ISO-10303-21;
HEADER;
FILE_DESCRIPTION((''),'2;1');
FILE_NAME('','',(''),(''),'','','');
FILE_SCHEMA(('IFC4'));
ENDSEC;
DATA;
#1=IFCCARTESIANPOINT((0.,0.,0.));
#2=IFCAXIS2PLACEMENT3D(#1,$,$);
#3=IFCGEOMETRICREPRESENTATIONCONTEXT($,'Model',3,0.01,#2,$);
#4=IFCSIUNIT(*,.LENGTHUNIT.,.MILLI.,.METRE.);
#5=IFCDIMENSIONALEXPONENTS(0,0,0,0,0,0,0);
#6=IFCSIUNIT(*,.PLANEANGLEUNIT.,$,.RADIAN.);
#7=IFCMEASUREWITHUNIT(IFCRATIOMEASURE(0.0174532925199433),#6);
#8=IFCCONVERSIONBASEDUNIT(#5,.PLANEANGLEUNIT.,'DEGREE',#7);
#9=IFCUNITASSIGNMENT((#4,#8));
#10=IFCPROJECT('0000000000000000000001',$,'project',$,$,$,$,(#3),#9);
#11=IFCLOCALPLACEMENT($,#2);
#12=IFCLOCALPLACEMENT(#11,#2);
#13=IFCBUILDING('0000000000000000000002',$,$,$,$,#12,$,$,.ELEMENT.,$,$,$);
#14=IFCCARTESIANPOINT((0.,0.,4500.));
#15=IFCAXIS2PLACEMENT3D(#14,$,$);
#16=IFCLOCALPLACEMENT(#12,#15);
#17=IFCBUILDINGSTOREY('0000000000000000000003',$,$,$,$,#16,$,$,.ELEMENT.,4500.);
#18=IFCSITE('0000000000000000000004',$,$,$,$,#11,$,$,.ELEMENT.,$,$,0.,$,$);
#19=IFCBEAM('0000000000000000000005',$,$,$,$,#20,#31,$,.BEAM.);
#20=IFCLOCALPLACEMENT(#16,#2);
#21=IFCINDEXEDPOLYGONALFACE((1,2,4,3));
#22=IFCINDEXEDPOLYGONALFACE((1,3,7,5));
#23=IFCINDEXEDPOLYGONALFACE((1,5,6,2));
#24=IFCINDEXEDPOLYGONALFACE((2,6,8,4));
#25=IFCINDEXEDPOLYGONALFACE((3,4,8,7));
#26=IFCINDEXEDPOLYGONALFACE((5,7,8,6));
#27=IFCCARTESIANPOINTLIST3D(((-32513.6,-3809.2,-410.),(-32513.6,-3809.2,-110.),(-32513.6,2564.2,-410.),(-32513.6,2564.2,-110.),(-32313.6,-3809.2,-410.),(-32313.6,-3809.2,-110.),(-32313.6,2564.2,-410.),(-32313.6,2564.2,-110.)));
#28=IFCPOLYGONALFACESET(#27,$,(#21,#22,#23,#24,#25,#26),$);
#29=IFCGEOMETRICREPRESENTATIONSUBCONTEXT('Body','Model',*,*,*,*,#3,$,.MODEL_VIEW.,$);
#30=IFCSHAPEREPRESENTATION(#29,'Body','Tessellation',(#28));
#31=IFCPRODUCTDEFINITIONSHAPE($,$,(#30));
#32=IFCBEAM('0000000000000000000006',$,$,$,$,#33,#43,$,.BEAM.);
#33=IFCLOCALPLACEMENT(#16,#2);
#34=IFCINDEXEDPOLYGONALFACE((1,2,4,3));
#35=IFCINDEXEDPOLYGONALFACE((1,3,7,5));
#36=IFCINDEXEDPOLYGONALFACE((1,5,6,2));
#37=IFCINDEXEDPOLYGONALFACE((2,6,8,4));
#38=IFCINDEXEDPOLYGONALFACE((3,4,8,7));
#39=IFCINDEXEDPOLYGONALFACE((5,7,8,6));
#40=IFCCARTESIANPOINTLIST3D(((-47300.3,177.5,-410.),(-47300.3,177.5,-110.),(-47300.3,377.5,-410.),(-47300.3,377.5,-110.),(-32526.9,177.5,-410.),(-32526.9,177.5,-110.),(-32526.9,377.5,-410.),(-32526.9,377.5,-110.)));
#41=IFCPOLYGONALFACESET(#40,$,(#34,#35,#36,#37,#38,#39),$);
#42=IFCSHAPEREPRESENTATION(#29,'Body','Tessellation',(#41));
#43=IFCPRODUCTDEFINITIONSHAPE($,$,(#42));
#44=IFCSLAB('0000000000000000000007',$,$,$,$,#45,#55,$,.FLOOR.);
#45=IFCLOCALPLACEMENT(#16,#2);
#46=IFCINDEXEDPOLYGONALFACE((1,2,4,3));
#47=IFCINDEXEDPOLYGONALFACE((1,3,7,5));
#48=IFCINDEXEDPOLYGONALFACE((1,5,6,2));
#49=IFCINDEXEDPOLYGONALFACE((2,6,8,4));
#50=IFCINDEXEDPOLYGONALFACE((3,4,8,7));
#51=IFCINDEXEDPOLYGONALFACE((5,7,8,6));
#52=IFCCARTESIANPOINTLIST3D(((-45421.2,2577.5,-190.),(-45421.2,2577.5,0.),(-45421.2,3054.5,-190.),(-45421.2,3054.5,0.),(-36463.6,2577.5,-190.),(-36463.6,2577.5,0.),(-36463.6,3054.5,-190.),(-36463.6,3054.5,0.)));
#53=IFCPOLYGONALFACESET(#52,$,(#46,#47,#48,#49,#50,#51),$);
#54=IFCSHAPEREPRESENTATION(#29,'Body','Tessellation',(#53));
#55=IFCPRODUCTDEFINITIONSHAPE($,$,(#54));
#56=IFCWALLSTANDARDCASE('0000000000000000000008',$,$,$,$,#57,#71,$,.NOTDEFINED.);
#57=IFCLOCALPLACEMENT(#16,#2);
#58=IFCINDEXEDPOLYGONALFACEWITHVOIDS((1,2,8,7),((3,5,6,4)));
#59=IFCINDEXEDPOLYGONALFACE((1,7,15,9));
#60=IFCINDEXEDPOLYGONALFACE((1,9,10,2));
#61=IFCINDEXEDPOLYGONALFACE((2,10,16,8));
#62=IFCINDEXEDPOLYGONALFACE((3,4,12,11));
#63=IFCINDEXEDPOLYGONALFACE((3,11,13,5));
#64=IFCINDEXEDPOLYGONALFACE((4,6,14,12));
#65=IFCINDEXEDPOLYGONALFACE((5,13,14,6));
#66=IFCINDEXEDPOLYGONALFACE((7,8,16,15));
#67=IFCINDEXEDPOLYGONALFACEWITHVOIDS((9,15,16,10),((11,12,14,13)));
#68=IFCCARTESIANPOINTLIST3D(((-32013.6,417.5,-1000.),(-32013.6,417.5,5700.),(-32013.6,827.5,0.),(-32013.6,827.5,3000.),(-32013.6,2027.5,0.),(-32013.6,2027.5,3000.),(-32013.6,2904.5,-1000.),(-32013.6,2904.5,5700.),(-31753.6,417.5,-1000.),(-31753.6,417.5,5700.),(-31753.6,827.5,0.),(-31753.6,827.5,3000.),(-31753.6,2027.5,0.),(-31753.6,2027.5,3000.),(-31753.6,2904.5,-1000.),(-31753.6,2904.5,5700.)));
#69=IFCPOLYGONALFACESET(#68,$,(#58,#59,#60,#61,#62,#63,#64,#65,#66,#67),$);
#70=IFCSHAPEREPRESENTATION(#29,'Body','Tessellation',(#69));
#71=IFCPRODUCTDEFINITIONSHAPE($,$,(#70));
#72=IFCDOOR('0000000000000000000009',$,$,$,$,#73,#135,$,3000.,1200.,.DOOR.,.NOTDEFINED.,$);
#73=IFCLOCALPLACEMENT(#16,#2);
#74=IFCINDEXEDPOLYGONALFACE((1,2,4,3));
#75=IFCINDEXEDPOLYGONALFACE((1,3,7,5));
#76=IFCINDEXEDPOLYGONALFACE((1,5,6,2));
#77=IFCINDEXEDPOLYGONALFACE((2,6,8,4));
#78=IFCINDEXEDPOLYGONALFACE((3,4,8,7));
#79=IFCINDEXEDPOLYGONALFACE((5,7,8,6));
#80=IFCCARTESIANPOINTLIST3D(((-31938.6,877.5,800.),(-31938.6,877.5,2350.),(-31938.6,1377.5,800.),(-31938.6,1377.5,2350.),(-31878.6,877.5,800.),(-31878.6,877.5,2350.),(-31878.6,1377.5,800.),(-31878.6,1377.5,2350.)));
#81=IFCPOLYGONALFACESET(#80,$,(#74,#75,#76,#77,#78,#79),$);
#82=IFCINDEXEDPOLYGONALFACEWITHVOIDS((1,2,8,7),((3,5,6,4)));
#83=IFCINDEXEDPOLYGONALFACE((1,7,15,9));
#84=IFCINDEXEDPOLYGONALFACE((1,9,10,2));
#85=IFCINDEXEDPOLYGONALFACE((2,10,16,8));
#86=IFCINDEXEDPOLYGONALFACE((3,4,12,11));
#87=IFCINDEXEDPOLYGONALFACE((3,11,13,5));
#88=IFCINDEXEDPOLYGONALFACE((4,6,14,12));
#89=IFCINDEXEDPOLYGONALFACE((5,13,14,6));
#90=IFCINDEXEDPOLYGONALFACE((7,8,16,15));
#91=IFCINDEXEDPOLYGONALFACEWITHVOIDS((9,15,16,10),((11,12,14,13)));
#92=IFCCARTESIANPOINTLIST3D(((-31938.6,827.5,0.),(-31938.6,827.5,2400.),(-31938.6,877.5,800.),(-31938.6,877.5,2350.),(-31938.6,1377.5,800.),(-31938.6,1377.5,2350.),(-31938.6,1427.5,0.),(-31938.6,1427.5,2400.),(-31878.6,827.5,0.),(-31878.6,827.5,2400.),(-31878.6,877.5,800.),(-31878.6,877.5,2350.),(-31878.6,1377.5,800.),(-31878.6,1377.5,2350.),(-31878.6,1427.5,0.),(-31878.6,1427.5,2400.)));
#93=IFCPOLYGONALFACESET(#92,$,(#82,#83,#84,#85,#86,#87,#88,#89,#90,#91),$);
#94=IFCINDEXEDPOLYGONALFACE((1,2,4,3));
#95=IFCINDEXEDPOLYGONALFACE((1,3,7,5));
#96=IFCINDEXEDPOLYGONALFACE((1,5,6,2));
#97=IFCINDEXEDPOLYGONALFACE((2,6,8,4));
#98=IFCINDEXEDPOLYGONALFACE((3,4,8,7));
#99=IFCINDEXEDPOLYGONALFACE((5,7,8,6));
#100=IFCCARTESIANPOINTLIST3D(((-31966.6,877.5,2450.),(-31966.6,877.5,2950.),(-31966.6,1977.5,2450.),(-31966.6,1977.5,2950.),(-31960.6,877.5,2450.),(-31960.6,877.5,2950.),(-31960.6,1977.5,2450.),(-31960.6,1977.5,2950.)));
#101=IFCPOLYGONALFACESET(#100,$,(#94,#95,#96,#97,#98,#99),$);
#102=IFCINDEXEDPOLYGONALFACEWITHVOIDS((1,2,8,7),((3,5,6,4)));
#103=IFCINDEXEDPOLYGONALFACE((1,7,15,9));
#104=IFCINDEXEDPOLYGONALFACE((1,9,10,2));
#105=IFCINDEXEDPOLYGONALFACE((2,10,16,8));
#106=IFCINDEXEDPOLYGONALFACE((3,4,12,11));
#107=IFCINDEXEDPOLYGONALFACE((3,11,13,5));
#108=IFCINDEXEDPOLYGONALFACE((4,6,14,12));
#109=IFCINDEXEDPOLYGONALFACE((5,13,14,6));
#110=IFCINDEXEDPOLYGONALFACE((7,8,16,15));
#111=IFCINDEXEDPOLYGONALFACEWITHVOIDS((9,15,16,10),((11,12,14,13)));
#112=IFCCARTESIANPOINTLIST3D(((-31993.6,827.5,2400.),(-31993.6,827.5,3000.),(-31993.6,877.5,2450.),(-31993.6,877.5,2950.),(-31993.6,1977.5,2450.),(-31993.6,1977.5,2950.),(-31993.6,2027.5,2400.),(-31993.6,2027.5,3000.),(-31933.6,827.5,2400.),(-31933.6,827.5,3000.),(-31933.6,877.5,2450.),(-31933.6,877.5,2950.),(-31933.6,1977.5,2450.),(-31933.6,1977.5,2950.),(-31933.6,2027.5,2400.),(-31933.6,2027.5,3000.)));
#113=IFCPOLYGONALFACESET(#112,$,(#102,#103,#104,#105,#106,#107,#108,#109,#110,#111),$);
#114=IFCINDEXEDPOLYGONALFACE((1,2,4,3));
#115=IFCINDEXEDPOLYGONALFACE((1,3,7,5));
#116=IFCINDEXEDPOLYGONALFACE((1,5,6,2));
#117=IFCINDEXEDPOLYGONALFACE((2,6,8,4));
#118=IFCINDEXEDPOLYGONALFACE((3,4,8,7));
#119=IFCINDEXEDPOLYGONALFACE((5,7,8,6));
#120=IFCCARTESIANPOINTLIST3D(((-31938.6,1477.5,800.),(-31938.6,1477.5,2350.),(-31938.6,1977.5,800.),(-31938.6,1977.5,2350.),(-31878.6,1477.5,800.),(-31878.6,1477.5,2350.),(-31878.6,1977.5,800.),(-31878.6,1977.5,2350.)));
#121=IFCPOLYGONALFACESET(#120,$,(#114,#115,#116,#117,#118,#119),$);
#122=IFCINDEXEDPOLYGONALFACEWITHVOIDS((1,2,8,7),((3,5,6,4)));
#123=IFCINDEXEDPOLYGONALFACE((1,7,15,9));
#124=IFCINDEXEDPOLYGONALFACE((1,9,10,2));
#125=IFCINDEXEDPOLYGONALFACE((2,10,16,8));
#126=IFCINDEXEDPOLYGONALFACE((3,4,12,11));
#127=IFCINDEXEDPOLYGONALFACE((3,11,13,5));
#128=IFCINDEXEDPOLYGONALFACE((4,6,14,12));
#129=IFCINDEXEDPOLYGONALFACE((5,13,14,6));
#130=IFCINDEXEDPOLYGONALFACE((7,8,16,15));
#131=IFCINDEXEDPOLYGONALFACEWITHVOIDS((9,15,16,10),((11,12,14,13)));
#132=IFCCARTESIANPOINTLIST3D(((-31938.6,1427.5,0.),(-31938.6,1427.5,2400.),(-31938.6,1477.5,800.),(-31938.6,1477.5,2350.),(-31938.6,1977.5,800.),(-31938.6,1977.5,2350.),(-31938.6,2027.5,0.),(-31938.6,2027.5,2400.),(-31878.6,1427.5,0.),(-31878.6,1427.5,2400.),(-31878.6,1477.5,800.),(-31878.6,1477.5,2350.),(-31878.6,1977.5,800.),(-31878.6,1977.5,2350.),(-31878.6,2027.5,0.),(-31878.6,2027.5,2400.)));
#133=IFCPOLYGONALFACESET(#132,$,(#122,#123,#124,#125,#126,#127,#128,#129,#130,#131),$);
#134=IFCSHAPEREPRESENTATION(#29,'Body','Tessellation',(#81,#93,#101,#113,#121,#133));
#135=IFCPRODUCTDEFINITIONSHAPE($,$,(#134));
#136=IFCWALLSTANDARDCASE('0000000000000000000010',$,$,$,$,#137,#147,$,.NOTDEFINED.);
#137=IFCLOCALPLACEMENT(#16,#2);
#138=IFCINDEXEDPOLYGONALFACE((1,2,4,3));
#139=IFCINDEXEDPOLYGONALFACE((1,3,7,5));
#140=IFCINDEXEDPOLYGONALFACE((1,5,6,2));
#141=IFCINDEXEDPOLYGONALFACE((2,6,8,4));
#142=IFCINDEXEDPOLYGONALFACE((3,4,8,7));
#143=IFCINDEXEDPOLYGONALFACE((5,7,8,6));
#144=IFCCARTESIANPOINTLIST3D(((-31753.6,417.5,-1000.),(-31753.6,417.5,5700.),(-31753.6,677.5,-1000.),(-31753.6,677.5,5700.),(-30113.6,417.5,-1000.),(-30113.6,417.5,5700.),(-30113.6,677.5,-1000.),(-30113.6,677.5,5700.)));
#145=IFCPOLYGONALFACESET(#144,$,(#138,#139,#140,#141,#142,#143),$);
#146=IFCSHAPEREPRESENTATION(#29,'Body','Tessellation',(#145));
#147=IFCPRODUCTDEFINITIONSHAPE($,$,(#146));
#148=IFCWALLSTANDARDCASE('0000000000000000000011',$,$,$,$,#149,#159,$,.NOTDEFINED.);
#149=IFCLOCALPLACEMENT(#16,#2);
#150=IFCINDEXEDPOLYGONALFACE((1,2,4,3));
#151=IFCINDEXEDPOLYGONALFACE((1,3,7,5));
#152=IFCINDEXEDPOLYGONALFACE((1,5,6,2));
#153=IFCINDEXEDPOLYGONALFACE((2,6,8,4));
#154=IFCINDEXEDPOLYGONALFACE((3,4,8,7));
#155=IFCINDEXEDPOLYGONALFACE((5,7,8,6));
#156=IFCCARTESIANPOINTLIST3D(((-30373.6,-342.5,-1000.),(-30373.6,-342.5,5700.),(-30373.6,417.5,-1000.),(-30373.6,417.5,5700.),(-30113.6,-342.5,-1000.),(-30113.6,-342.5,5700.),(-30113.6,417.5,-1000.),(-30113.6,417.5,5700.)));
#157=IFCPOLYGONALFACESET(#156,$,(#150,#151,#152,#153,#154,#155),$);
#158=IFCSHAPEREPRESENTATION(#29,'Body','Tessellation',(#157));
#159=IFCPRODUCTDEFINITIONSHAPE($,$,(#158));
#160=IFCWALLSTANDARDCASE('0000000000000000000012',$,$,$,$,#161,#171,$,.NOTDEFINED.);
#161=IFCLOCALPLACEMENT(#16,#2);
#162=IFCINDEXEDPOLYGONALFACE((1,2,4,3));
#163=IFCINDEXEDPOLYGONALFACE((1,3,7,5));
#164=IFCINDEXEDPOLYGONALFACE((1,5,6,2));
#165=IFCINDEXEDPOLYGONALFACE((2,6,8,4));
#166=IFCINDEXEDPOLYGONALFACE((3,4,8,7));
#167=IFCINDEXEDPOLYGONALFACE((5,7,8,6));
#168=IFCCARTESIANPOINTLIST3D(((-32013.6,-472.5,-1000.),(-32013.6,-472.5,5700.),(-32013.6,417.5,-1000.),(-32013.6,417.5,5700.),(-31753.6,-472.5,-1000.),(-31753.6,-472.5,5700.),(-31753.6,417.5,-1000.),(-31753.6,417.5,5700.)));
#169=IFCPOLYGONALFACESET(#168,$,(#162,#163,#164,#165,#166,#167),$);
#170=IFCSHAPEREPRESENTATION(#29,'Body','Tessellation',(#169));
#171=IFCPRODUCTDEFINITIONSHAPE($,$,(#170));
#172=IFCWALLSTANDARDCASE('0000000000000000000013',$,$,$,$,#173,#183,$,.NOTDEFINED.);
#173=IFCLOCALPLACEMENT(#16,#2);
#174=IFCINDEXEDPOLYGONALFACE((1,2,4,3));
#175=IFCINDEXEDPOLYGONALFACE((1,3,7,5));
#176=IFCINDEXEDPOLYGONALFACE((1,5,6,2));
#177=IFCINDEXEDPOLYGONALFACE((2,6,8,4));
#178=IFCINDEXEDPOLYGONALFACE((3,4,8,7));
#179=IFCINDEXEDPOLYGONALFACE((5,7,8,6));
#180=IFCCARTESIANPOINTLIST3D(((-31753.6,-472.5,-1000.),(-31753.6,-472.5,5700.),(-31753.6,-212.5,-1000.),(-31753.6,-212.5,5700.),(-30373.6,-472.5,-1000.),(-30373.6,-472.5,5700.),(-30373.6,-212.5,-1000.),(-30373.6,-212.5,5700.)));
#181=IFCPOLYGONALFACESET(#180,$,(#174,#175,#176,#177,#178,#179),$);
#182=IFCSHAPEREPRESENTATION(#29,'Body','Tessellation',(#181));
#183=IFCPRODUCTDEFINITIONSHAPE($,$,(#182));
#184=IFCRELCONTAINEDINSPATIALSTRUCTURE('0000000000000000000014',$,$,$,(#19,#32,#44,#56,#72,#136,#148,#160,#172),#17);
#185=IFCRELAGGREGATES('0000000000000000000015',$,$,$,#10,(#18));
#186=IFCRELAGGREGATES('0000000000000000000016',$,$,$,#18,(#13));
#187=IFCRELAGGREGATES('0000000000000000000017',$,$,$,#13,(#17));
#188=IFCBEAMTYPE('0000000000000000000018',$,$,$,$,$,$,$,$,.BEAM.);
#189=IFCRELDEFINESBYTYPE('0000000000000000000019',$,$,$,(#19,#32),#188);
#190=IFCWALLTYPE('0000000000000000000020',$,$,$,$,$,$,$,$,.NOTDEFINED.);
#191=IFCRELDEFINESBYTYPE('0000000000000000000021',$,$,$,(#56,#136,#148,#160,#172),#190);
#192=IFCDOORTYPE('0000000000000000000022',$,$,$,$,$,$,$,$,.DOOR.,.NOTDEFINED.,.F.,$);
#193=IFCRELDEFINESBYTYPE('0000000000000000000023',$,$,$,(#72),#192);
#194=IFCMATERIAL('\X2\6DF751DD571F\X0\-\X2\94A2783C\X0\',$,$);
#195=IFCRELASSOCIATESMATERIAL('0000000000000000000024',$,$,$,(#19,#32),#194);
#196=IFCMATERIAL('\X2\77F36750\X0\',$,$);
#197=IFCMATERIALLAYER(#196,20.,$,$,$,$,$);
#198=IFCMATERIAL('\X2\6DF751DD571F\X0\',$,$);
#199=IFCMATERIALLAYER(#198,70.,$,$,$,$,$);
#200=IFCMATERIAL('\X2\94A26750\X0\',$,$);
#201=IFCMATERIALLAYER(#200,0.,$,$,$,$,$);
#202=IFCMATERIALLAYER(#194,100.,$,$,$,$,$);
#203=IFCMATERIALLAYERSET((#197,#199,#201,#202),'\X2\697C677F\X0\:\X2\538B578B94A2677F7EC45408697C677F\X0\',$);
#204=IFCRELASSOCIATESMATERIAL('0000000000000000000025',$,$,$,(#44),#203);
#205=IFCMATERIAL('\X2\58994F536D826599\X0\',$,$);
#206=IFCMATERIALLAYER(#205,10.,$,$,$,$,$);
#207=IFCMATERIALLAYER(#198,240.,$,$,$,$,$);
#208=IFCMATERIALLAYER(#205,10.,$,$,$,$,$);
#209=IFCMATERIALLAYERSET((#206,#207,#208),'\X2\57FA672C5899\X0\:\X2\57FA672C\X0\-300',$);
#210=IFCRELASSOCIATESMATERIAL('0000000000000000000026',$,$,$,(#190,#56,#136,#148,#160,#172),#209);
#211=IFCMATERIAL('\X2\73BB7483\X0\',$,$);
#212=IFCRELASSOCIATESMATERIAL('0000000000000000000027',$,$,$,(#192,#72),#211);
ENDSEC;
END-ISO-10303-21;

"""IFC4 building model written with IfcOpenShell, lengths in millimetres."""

from ifc_helpers import new_model, entity, si_unit, converted_unit, frame, frame_2d, origin, origin_2d_with_axis, place, context, subcontext, project, spatial, polyline, rectangle, outline, extrude, source, transform, mapped, material, layer, layer_set, layer_usage, type_object, type_shapes, element, fill, save


model = new_model("IFC4")

# Units and contexts
model_context = context("Model", 3, precision=0.01, world=origin())
body_context = subcontext(model_context, "Body", "Model", "MODEL_VIEW")
ifc_project = project(units=[si_unit("LENGTHUNIT", "METRE", prefix="MILLI"), converted_unit("PLANEANGLEUNIT", "DEGREE", entity("IfcRatioMeasure", 0.0174532925199433), si_unit("PLANEANGLEUNIT", "RADIAN"), dimensions=[0, 0, 0, 0, 0, 0, 0])], contexts=[model_context])

# Site, building, storey
site_placement = place(None, origin())
site = spatial("IfcSite", under=ifc_project, at=site_placement, CompositionType="ELEMENT", RefElevation=0.0)
building_placement = place(site_placement, origin())
building = spatial("IfcBuilding", under=site, at=building_placement, CompositionType="ELEMENT")
storey_placement = place(building_placement, frame((0.0, 0.0, 4500.0)))
storey = spatial("IfcBuildingStorey", under=building, at=storey_placement, CompositionType="ELEMENT", Elevation=4500.0)

# Beams
ifc_material_1 = material(Name="混凝土-钢砼")
beam_type = type_object("IfcBeamType", PredefinedType="BEAM")
beam_1_placement = place(storey_placement, frame((-32413.6, 2677.5, -110.0), z_axis=(0.0, 0.0, 1.0), x_axis=(0.0, -1.0, 0.0)))
element("IfcBeam", 1, at=beam_1_placement, inside=storey, type_object=beam_type, material=ifc_material_1, PredefinedType="BEAM", context=body_context, shape_type="SweptSolid", body=[
    extrude(rectangle(XDim=300.0, YDim=200.0, at=frame_2d((0.0, 0.0), x_axis=(1.0, 0.0))), frame((113.3, 0.0, -150.0), z_axis=(1.0, 0.0, 0.0), x_axis=(0.0, 0.0, -1.0)), (0.0, 0.0, 1.0), 6373.4),
])
beam_2_placement = place(storey_placement, frame((-32413.6, 277.5, -110.0), z_axis=(0.0, 0.0, 1.0), x_axis=(-1.0, 0.0, 0.0)))
element("IfcBeam", 2, at=beam_2_placement, inside=storey, type_object=beam_type, material=ifc_material_1, PredefinedType="BEAM", context=body_context, shape_type="SweptSolid", body=[
    extrude(rectangle(XDim=300.0, YDim=200.0, at=frame_2d((0.0, 0.0), x_axis=(1.0, 0.0))), frame((113.3, 0.0, -150.0), z_axis=(1.0, 0.0, 0.0), x_axis=(0.0, 0.0, -1.0)), (0.0, 0.0, 1.0), 14773.4),
])

# Slab
ifc_material_2 = material(Name="石材")
ifc_layer_1 = layer(ifc_material_2, 20.0)
ifc_material_3 = material(Name="混凝土")
ifc_layer_2 = layer(ifc_material_3, 70.0)
ifc_material_4 = material(Name="钢材")
ifc_layer_3 = layer(ifc_material_4, 0.0)
ifc_layer_4 = layer(ifc_material_1, 100.0)
ifc_layer_set_1 = layer_set([ifc_layer_1, ifc_layer_2, ifc_layer_3, ifc_layer_4], Name="楼板:压型钢板组合楼板")
ifc_layer_usage_1 = layer_usage(ifc_layer_set_1, "AXIS3", "POSITIVE", 0.0)
slab_1_placement = place(storey_placement, origin())
element("IfcSlab", 3, at=slab_1_placement, inside=storey, material=ifc_layer_usage_1, PredefinedType="FLOOR", context=body_context, shape_type="SweptSolid", body=[
    extrude(rectangle(XDim=477.0, YDim=8957.6, at=frame_2d((0.0, 0.0), x_axis=(1.0, 0.0))), frame((-40942.4, 2816.0, 0.0), z_axis=(0.0, 0.0, -1.0), x_axis=(0.0, 1.0, 0.0)), (0.0, 0.0, 1.0), 190.0),
])

# Wall, opening, door
ifc_material_5 = material(Name="墙体涂料")
ifc_layer_5 = layer(ifc_material_5, 10.0)
ifc_layer_6 = layer(ifc_material_3, 240.0)
ifc_layer_7 = layer(ifc_material_5, 10.0)
ifc_layer_set_2 = layer_set([ifc_layer_5, ifc_layer_6, ifc_layer_7], Name="基本墙:基本-300")
ifc_layer_usage_2 = layer_usage(ifc_layer_set_2, "AXIS2", "POSITIVE", -130.0)
wall_type = type_object("IfcWallType", PredefinedType="NOTDEFINED", material=ifc_layer_set_2)
wall_1_placement = place(storey_placement, frame((-31883.6, 2904.5, -1000.0), z_axis=(0.0, 0.0, 1.0), x_axis=(0.0, -1.0, 0.0)))
wall_1 = element("IfcWallStandardCase", 4, at=wall_1_placement, inside=storey, type_object=wall_type, material=ifc_layer_usage_2, PredefinedType="NOTDEFINED", context=body_context, shape_type="SweptSolid", body=[
    extrude(rectangle(XDim=2487.0, YDim=260.0, at=frame_2d((1243.5, 0.0), x_axis=(-1.0, 0.0))), origin(), (0.0, 0.0, 1.0), 6700.0),
])
opening_1_placement = place(wall_1_placement, frame((877.0, -130.0, 1000.0)))
opening_1 = element("IfcOpeningElement", 5, at=opening_1_placement, cuts=wall_1, PredefinedType="OPENING", context=body_context, shape_type="SweptSolid", body=[
    extrude(rectangle(XDim=3000.0, YDim=1200.0, at=frame_2d((1500.0, 600.0), x_axis=(1.0, 0.0))), frame((0.0, 0.0, 0.0), z_axis=(0.0, 1.0, 0.0), x_axis=(0.0, 0.0, 1.0)), (0.0, 0.0, 1.0), 260.0),
])
ifc_material_6 = material(Name="玻璃")
door_type = type_object("IfcDoorType", OperationType="NOTDEFINED", ParameterTakesPrecedence=False, PredefinedType="DOOR", material=ifc_material_6)
shared_shape_1 = source(origin(), body_context, "Body", "SweptSolid", [
    extrude(rectangle(XDim=60.0, YDim=500.0, at=origin_2d_with_axis()), frame((900.0, 105.0, 800.0), z_axis=(0.0, 0.0, 1.0), x_axis=(0.0, -1.0, 0.0)), (0.0, 0.0, 1.0), 1550.0),
    extrude(outline(polyline([(-300.0, -1200.0), (300.0, -1200.0), (300.0, 1200.0), (-300.0, 1200.0), (-300.0, -1200.0)]), holes=[polyline([(250.0, -1150.0), (-250.0, -1150.0), (-250.0, 400.0), (250.0, 400.0), (250.0, -1150.0)])]), frame((900.0, 75.0, 1200.0), z_axis=(0.0, 1.0, 0.0), x_axis=(1.0, 0.0, 0.0)), (0.0, 0.0, 1.0), 60.0),
    extrude(rectangle(XDim=6.0, YDim=1100.0, at=frame_2d((0.0, 0.0), x_axis=(1.0, 0.0))), frame((600.0, 50.0, 2450.0), z_axis=(0.0, 0.0, 1.0), x_axis=(0.0, -1.0, 0.0)), (0.0, 0.0, 1.0), 500.0),
    extrude(outline(polyline([(-600.0, -300.0), (600.0, -300.0), (600.0, 300.0), (-600.0, 300.0), (-600.0, -300.0)]), holes=[polyline([(-550.0, -250.0), (-550.0, 250.0), (550.0, 250.0), (550.0, -250.0), (-550.0, -250.0)])]), frame((600.0, 20.0, 2700.0), z_axis=(0.0, 1.0, 0.0), x_axis=(1.0, 0.0, 0.0)), (0.0, 0.0, 1.0), 60.0),
    extrude(rectangle(XDim=500.0, YDim=60.0, at=frame_2d((0.0, 0.0), x_axis=(1.0, 0.0))), frame((300.0, 105.0, 800.0), z_axis=(0.0, 0.0, 1.0), x_axis=(-1.0, 0.0, 0.0)), (0.0, 0.0, 1.0), 1550.0),
    extrude(outline(polyline([(-1200.0, -300.0), (1200.0, -300.0), (1200.0, 300.0), (-1200.0, 300.0), (-1200.0, -300.0)]), holes=[polyline([(-1150.0, 250.0), (400.0, 250.0), (400.0, -250.0), (-1150.0, -250.0), (-1150.0, 250.0)])]), frame((300.0, 75.0, 1200.0), z_axis=(0.0, 1.0, 0.0), x_axis=(0.0, 0.0, -1.0)), (0.0, 0.0, 1.0), 60.0),
])
type_shapes(door_type, [shared_shape_1])
door_placement = place(opening_1_placement, origin())
door = element("IfcDoor", 6, at=door_placement, inside=storey, type_object=door_type, material=ifc_material_6, OperationType="NOTDEFINED", OverallHeight=3000.0, OverallWidth=1200.0, PredefinedType="DOOR", context=body_context, shape_type="MappedRepresentation", body=[
    mapped(shared_shape_1, transform((0.0, 0.0, 0.0), scale=1.0)),
])
fill(opening_1, door)

# Walls
ifc_layer_usage_3 = layer_usage(ifc_layer_set_2, "AXIS2", "NEGATIVE", 130.0)
wall_2_placement = place(storey_placement, frame((-31753.6, 547.5, -1000.0)))
element("IfcWallStandardCase", 7, at=wall_2_placement, inside=storey, type_object=wall_type, material=ifc_layer_usage_3, PredefinedType="NOTDEFINED", context=body_context, shape_type="SweptSolid", body=[
    extrude(rectangle(XDim=1640.0, YDim=260.0, at=frame_2d((820.0, 0.0), x_axis=(-1.0, 0.0))), origin(), (0.0, 0.0, 1.0), 6700.0),
])
ifc_layer_usage_4 = layer_usage(ifc_layer_set_2, "AXIS2", "NEGATIVE", 130.0)
wall_3_placement = place(storey_placement, frame((-30243.6, 417.5, -1000.0), z_axis=(0.0, 0.0, 1.0), x_axis=(0.0, -1.0, 0.0)))
element("IfcWallStandardCase", 8, at=wall_3_placement, inside=storey, type_object=wall_type, material=ifc_layer_usage_4, PredefinedType="NOTDEFINED", context=body_context, shape_type="SweptSolid", body=[
    extrude(rectangle(XDim=760.0, YDim=260.0, at=frame_2d((380.0, 0.0), x_axis=(-1.0, 0.0))), origin(), (0.0, 0.0, 1.0), 6700.0),
])
ifc_layer_usage_5 = layer_usage(ifc_layer_set_2, "AXIS2", "POSITIVE", -130.0)
wall_4_placement = place(storey_placement, frame((-31883.6, 417.5, -1000.0), z_axis=(0.0, 0.0, 1.0), x_axis=(0.0, -1.0, 0.0)))
element("IfcWallStandardCase", 9, at=wall_4_placement, inside=storey, type_object=wall_type, material=ifc_layer_usage_5, PredefinedType="NOTDEFINED", context=body_context, shape_type="SweptSolid", body=[
    extrude(rectangle(XDim=890.0, YDim=260.0, at=frame_2d((445.0, 0.0), x_axis=(-1.0, 0.0))), origin(), (0.0, 0.0, 1.0), 6700.0),
])
ifc_layer_usage_6 = layer_usage(ifc_layer_set_2, "AXIS2", "POSITIVE", -130.0)
wall_5_placement = place(storey_placement, frame((-31753.6, -342.5, -1000.0)))
element("IfcWallStandardCase", 10, at=wall_5_placement, inside=storey, type_object=wall_type, material=ifc_layer_usage_6, PredefinedType="NOTDEFINED", context=body_context, shape_type="SweptSolid", body=[
    extrude(rectangle(XDim=1380.0, YDim=260.0, at=frame_2d((690.0, 0.0), x_axis=(-1.0, 0.0))), origin(), (0.0, 0.0, 1.0), 6700.0),
])

save(model, "model.ifc")
